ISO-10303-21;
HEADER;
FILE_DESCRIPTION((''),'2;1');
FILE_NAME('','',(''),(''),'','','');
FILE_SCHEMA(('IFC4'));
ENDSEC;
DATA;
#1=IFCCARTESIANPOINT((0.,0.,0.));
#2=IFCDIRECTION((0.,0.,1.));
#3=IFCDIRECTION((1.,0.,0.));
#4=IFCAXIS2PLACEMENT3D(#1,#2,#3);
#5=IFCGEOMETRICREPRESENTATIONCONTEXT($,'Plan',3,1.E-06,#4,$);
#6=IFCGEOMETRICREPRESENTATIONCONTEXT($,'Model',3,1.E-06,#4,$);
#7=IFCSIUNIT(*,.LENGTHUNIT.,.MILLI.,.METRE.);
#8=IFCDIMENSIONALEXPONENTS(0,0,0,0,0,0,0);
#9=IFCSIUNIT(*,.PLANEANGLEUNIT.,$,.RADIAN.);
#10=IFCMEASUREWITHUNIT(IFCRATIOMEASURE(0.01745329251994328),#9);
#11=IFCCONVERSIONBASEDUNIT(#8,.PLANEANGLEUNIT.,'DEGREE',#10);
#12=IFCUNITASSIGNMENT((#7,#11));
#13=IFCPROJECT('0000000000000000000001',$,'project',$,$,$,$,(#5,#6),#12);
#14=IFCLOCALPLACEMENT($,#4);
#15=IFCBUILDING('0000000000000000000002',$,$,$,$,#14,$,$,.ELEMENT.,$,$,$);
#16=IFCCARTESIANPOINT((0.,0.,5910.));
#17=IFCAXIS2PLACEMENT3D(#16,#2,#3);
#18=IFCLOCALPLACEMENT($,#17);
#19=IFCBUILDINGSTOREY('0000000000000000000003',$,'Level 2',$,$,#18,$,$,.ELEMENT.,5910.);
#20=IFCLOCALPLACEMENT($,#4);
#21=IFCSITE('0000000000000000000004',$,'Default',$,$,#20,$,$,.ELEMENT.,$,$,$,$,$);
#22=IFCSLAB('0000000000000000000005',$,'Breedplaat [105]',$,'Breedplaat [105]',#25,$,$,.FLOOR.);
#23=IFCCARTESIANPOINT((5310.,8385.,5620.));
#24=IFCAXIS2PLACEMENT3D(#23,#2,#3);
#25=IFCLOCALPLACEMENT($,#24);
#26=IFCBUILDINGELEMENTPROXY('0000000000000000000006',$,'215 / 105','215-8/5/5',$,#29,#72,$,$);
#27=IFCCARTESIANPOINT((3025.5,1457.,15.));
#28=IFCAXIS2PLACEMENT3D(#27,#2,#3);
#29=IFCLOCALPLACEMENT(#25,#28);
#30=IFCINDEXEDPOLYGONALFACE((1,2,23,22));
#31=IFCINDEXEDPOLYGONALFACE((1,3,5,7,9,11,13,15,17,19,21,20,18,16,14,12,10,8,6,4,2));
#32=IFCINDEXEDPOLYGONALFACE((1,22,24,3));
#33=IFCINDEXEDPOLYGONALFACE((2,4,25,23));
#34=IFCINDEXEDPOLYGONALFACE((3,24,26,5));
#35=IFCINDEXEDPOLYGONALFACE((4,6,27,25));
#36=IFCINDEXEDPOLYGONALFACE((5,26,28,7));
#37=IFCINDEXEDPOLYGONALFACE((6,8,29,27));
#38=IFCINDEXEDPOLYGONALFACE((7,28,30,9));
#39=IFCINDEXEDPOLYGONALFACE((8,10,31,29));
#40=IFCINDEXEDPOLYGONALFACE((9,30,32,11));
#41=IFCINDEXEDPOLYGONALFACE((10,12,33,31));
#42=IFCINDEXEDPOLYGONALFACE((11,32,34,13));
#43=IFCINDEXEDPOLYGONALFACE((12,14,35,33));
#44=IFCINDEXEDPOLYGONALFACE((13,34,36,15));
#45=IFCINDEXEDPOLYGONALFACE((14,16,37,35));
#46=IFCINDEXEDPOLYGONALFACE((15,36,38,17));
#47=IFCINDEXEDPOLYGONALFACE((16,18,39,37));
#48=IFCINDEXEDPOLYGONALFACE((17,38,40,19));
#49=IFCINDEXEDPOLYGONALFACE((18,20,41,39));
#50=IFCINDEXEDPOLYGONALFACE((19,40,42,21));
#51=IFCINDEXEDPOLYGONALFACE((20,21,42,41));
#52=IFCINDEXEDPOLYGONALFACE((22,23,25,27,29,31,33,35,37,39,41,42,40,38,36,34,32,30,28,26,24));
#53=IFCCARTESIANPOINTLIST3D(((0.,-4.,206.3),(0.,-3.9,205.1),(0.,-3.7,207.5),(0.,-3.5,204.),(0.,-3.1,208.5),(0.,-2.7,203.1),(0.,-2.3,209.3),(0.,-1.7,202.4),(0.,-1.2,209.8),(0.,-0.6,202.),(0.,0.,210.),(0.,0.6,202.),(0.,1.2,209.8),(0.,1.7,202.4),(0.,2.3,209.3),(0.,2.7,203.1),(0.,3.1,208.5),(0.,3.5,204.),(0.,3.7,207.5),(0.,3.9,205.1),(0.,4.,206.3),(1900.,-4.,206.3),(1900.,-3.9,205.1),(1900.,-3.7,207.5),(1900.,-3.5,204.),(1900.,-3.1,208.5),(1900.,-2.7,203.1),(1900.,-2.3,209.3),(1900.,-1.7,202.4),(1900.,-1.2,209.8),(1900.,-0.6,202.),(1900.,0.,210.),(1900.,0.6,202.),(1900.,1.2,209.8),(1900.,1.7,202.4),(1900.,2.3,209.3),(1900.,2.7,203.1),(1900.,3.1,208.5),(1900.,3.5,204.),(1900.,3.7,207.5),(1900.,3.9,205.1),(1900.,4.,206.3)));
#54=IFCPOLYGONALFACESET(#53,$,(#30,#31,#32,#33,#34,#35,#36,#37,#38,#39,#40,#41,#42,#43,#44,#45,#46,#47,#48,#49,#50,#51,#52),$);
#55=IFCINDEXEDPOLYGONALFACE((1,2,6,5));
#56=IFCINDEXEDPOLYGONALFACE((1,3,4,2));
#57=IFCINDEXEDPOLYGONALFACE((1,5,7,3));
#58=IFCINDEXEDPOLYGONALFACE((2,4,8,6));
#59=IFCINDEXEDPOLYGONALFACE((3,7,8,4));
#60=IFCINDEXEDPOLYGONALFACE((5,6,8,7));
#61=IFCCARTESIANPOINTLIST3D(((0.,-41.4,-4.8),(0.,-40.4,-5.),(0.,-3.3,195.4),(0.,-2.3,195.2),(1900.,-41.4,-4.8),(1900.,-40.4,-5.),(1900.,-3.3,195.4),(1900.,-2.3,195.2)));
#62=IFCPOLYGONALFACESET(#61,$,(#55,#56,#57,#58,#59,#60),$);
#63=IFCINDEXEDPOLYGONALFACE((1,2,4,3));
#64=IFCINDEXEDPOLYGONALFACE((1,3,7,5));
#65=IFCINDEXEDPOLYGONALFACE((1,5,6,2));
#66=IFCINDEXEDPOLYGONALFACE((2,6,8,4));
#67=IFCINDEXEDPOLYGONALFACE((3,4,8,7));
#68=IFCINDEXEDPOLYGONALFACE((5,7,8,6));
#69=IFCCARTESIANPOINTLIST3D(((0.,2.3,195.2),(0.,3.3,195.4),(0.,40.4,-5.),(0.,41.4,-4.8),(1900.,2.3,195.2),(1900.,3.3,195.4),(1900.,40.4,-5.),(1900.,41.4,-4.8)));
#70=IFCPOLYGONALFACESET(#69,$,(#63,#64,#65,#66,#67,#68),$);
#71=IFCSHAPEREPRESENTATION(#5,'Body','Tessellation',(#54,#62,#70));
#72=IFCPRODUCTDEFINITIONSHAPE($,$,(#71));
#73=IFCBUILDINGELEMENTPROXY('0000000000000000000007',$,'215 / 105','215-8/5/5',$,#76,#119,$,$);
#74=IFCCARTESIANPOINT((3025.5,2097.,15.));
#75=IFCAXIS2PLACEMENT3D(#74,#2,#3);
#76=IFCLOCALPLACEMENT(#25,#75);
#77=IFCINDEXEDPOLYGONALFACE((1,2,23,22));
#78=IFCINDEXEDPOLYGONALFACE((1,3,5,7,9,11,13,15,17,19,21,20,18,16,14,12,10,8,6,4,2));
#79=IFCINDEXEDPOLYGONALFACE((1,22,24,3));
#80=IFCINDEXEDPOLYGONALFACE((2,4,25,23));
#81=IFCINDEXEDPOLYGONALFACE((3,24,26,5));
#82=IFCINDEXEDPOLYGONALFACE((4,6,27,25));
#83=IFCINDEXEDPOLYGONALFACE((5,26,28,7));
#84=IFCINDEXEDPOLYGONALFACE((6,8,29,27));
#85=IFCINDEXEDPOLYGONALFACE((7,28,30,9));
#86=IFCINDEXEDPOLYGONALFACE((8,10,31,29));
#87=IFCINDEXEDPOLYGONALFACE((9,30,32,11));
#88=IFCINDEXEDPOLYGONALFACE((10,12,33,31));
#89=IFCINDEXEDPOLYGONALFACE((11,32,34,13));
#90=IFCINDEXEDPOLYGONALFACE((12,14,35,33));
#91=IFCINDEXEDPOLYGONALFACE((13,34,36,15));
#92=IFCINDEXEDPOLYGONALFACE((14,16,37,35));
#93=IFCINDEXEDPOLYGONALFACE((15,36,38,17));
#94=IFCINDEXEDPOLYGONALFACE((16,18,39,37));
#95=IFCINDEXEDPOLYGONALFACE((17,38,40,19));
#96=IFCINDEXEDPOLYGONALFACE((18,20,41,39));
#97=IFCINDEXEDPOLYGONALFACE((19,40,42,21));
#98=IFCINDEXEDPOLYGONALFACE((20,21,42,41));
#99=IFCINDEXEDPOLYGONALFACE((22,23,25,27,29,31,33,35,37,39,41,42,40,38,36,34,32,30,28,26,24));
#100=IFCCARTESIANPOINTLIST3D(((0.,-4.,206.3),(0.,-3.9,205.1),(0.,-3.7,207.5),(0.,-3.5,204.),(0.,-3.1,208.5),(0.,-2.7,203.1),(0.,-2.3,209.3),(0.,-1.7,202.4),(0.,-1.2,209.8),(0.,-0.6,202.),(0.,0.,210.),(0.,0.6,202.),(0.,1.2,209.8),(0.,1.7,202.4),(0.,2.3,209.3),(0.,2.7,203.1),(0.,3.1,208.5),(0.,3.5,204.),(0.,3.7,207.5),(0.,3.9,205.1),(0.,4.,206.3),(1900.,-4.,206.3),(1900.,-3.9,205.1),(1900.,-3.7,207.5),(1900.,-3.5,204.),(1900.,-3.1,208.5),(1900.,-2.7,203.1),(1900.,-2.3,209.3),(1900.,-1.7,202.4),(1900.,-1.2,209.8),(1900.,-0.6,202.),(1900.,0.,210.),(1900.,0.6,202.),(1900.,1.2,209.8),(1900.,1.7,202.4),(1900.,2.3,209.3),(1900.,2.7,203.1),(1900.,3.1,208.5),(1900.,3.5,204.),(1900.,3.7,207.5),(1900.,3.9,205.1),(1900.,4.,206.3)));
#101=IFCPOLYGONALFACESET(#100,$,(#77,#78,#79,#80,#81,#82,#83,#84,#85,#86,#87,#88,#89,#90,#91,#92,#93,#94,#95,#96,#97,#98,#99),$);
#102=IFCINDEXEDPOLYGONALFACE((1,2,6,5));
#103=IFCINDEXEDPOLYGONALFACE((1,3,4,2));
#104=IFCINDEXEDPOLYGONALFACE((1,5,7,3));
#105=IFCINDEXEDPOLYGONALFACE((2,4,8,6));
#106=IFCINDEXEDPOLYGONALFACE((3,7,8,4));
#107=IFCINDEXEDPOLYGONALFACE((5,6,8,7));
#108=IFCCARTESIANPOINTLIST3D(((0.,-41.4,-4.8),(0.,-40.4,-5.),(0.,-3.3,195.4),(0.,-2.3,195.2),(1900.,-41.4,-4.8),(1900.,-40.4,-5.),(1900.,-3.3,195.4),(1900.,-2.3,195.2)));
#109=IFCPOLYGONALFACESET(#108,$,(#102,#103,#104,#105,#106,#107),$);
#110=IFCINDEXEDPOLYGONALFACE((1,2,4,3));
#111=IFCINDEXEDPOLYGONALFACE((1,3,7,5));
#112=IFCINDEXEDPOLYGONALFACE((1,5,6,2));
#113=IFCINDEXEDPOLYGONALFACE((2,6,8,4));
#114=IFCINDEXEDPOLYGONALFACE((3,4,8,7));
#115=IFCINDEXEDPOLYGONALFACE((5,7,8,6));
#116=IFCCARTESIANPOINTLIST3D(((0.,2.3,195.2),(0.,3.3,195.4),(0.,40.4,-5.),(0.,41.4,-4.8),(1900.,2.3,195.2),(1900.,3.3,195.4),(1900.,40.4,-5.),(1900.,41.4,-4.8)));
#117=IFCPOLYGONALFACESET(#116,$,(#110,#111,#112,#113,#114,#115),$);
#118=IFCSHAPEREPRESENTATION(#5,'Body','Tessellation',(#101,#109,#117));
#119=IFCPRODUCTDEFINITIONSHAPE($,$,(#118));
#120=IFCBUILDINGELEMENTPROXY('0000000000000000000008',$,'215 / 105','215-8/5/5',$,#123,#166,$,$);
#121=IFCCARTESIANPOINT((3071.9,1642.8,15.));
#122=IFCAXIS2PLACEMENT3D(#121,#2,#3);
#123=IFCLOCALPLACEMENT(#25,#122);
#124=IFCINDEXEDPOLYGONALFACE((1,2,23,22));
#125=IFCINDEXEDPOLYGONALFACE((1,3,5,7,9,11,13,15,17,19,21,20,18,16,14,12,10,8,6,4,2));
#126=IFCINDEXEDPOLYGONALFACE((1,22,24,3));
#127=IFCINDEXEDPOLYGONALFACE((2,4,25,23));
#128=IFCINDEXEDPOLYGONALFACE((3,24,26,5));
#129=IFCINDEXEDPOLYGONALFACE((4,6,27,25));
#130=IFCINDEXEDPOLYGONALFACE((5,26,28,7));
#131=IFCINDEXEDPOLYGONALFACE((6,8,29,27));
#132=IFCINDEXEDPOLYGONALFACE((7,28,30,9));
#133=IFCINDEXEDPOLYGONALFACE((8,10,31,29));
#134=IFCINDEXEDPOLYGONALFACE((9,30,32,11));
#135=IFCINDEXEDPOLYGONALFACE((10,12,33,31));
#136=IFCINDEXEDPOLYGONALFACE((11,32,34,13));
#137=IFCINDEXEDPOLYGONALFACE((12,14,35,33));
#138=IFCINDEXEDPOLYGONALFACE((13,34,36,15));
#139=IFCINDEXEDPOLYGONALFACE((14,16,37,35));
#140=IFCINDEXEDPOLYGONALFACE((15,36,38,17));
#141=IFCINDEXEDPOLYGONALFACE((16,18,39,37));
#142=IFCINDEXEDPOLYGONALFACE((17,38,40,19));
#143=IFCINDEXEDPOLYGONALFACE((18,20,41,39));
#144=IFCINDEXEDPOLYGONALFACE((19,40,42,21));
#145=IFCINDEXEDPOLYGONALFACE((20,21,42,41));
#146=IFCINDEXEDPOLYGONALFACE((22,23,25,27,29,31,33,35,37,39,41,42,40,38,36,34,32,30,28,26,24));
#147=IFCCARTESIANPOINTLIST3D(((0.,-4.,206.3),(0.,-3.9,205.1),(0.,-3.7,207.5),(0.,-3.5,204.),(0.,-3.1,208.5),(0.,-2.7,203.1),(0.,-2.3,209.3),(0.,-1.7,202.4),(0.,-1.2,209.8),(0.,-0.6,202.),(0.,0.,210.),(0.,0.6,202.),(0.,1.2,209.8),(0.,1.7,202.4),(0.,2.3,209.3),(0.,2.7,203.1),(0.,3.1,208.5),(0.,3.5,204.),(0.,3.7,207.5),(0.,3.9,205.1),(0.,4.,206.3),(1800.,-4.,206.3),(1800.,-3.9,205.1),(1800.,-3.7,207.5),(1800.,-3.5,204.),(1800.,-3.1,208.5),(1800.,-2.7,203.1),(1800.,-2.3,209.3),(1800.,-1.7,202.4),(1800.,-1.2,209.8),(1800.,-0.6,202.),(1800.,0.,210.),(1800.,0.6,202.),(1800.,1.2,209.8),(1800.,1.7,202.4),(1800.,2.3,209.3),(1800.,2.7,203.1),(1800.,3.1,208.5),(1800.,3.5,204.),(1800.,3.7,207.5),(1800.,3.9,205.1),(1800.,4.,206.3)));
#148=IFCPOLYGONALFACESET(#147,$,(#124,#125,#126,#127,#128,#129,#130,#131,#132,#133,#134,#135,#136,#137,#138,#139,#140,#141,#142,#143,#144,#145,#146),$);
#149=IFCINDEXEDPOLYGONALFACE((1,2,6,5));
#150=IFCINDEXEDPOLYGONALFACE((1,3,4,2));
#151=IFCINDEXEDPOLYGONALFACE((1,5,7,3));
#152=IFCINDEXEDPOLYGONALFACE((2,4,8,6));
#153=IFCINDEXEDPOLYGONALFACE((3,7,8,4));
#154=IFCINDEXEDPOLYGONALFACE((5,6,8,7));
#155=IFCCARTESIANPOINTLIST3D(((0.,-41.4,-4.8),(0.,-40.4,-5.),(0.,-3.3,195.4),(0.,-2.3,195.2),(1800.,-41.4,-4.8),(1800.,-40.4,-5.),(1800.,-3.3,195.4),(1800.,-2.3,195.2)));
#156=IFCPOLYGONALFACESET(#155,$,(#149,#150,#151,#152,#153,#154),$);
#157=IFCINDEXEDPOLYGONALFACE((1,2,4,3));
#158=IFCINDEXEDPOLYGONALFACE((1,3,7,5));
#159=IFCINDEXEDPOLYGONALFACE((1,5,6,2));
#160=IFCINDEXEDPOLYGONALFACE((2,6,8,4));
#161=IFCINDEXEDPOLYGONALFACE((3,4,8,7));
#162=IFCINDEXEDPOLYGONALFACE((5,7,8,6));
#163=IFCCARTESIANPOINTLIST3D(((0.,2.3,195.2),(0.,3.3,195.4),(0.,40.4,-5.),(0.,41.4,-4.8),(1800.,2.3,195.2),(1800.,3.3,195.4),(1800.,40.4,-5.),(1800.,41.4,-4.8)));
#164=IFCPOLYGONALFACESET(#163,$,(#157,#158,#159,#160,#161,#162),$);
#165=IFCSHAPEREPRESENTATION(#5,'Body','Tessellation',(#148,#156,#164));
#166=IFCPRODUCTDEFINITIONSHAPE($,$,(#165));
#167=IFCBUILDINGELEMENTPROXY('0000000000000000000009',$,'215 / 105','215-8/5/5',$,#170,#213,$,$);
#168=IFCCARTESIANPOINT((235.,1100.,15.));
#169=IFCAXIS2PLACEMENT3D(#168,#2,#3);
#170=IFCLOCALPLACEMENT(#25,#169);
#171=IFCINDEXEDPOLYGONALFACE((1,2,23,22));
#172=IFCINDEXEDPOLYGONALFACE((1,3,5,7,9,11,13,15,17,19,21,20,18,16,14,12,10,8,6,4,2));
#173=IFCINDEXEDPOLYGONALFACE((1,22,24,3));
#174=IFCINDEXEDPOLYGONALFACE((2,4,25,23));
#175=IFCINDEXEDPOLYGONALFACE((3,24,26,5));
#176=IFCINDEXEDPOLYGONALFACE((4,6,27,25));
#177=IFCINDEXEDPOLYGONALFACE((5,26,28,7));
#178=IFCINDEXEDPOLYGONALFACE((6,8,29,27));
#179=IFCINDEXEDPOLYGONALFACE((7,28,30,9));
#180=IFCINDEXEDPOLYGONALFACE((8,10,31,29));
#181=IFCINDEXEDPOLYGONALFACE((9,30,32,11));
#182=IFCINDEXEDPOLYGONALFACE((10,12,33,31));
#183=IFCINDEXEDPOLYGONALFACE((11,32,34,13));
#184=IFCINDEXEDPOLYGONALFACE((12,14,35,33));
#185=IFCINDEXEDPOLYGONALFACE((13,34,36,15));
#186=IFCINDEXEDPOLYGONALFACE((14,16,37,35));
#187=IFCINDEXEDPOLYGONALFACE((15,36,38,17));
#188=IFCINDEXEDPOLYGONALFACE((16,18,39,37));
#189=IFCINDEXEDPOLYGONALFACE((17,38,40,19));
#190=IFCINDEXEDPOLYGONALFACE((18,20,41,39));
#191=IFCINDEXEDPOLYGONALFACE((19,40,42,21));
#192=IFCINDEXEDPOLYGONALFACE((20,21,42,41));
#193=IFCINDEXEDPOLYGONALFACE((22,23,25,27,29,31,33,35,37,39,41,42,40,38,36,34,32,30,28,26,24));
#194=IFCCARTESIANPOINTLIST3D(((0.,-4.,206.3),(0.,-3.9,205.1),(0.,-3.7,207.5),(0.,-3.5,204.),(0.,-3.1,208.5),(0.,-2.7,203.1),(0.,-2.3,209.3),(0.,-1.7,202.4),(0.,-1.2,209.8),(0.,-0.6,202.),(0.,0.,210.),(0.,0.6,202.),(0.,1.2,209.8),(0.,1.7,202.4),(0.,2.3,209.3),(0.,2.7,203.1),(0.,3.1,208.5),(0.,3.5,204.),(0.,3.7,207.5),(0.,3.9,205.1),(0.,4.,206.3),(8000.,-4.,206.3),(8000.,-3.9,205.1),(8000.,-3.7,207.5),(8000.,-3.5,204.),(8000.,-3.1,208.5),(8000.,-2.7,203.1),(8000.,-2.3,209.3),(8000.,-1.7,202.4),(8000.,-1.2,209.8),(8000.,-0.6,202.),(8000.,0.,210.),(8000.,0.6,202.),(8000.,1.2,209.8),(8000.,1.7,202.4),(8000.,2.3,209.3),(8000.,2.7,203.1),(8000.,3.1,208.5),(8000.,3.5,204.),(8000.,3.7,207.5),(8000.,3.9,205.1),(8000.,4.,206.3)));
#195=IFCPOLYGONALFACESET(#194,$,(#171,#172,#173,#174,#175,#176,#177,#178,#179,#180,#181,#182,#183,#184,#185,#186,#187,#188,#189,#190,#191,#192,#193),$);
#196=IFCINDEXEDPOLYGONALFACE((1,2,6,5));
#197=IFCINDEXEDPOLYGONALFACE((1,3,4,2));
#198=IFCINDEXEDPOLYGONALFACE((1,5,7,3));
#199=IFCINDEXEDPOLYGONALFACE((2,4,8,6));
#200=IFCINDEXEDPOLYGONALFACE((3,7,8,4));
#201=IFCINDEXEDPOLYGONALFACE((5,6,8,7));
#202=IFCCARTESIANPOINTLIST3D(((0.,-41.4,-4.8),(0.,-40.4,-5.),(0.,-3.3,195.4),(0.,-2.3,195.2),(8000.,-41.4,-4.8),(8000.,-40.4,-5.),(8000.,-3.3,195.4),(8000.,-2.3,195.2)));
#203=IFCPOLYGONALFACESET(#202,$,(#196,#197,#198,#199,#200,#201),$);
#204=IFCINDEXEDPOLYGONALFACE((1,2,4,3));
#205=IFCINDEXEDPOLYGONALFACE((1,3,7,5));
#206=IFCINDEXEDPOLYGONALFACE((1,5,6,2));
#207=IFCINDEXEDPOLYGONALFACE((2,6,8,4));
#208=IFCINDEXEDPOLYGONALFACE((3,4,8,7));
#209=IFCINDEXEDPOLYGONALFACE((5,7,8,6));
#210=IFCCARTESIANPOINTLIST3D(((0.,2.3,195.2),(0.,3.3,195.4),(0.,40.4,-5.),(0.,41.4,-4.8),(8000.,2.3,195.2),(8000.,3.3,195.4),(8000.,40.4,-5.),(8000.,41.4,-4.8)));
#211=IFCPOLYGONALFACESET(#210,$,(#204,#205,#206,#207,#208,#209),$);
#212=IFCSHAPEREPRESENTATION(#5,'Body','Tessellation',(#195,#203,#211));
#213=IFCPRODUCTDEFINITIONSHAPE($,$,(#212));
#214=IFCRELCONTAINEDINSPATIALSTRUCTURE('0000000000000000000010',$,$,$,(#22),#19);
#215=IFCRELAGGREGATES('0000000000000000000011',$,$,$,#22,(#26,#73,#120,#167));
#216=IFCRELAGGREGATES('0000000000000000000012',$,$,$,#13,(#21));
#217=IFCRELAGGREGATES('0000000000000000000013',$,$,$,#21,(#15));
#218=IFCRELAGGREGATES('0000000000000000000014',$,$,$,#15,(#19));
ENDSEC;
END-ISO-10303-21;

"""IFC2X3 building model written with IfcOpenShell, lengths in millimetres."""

from ifc_helpers import new_model, entity, si_unit, converted_unit, frame, origin_with_axes, origin_2d_with_axis, place, context, project, spatial, rectangle, circle, extrude, element, aggregate, save


model = new_model("IFC2X3")

# Units and contexts
plan_context = context("Plan", 3, precision=1e-06, world=origin_with_axes())
model_context = context("Model", 3, precision=1e-06, world=origin_with_axes())
ifc_project = project(units=[si_unit("LENGTHUNIT", "METRE", prefix="MILLI"), converted_unit("PLANEANGLEUNIT", "DEGREE", entity("IfcRatioMeasure", 0.01745329251994328), si_unit("PLANEANGLEUNIT", "RADIAN"), dimensions=[0, 0, 0, 0, 0, 0, 0])], contexts=[plan_context, model_context])

# Site, building, storey
site_placement = place(None, origin_with_axes())
site = spatial("IfcSite", under=ifc_project, at=site_placement, Name="Default", CompositionType="ELEMENT")
building_placement = place(None, origin_with_axes())
building = spatial("IfcBuilding", under=site, at=building_placement, CompositionType="ELEMENT")
storey_placement = place(None, frame((0.0, 0.0, 5910.0), z_axis=(0.0, 0.0, 1.0), x_axis=(1.0, 0.0, 0.0)))
storey = spatial("IfcBuildingStorey", under=building, at=storey_placement, Name="Level 2", CompositionType="ELEMENT", Elevation=5910.0)

# Slab, building element proxies
slab_1_placement = place(None, frame((5310.0, 8385.0, 5620.0), z_axis=(0.0, 0.0, 1.0), x_axis=(1.0, 0.0, 0.0)))
slab_1 = element("IfcSlab", 1, at=slab_1_placement, inside=storey, Name="Breedplaat [105]", ObjectType="Breedplaat [105]", PredefinedType="FLOOR")
proxy_1_placement = place(slab_1_placement, frame((3025.5, 1457.0, 15.0), z_axis=(0.0, 0.0, 1.0), x_axis=(1.0, 0.0, 0.0)))
proxy_1 = element("IfcBuildingElementProxy", 2, at=proxy_1_placement, Name="215 / 105", Description="215-8/5/5", context=plan_context, shape_type="SweptSolid", body=[
    extrude(circle(Radius=4.0, at=origin_2d_with_axis()), frame((0.0, 0.0, 206.0), z_axis=(1.0, 0.0, 0.0), x_axis=(0.0, 0.0, 1.0)), (0.0, 0.0, 1.0), 1900.0),
    extrude(rectangle(XDim=203.8, YDim=1.0, at=origin_2d_with_axis()), frame((0.0, -21.9, 95.2), z_axis=(1.0, 0.0, 0.0), x_axis=(0.0, 0.187112, 0.982339)), (0.0, 0.0, 1.0), 1900.0),
    extrude(rectangle(XDim=203.8, YDim=1.0, at=origin_2d_with_axis()), frame((0.0, 21.9, 95.2), z_axis=(1.0, 0.0, 0.0), x_axis=(0.0, -0.187112, 0.982339)), (0.0, 0.0, 1.0), 1900.0),
])
proxy_2_placement = place(slab_1_placement, frame((3025.5, 2097.0, 15.0), z_axis=(0.0, 0.0, 1.0), x_axis=(1.0, 0.0, 0.0)))
proxy_2 = element("IfcBuildingElementProxy", 3, at=proxy_2_placement, Name="215 / 105", Description="215-8/5/5", context=plan_context, shape_type="SweptSolid", body=[
    extrude(circle(Radius=4.0, at=origin_2d_with_axis()), frame((0.0, 0.0, 206.0), z_axis=(1.0, 0.0, 0.0), x_axis=(0.0, 0.0, 1.0)), (0.0, 0.0, 1.0), 1900.0),
    extrude(rectangle(XDim=203.8, YDim=1.0, at=origin_2d_with_axis()), frame((0.0, -21.9, 95.2), z_axis=(1.0, 0.0, 0.0), x_axis=(0.0, 0.187112, 0.982339)), (0.0, 0.0, 1.0), 1900.0),
    extrude(rectangle(XDim=203.8, YDim=1.0, at=origin_2d_with_axis()), frame((0.0, 21.9, 95.2), z_axis=(1.0, 0.0, 0.0), x_axis=(0.0, -0.187112, 0.982339)), (0.0, 0.0, 1.0), 1900.0),
])
proxy_3_placement = place(slab_1_placement, frame((3071.9, 1642.8, 15.0), z_axis=(0.0, 0.0, 1.0), x_axis=(1.0, 0.0, 0.0)))
proxy_3 = element("IfcBuildingElementProxy", 4, at=proxy_3_placement, Name="215 / 105", Description="215-8/5/5", context=plan_context, shape_type="SweptSolid", body=[
    extrude(circle(Radius=4.0, at=origin_2d_with_axis()), frame((0.0, 0.0, 206.0), z_axis=(1.0, 0.0, 0.0), x_axis=(0.0, 0.0, 1.0)), (0.0, 0.0, 1.0), 1800.0),
    extrude(rectangle(XDim=203.8, YDim=1.0, at=origin_2d_with_axis()), frame((0.0, -21.9, 95.2), z_axis=(1.0, 0.0, 0.0), x_axis=(0.0, 0.187112, 0.982339)), (0.0, 0.0, 1.0), 1800.0),
    extrude(rectangle(XDim=203.8, YDim=1.0, at=origin_2d_with_axis()), frame((0.0, 21.9, 95.2), z_axis=(1.0, 0.0, 0.0), x_axis=(0.0, -0.187112, 0.982339)), (0.0, 0.0, 1.0), 1800.0),
])
proxy_4_placement = place(slab_1_placement, frame((235.0, 1100.0, 15.0), z_axis=(0.0, 0.0, 1.0), x_axis=(1.0, 0.0, 0.0)))
proxy_4 = element("IfcBuildingElementProxy", 5, at=proxy_4_placement, Name="215 / 105", Description="215-8/5/5", context=plan_context, shape_type="SweptSolid", body=[
    extrude(circle(Radius=4.0, at=origin_2d_with_axis()), frame((0.0, 0.0, 206.0), z_axis=(1.0, 0.0, 0.0), x_axis=(0.0, 0.0, 1.0)), (0.0, 0.0, 1.0), 8000.0),
    extrude(rectangle(XDim=203.8, YDim=1.0, at=origin_2d_with_axis()), frame((0.0, -21.9, 95.2), z_axis=(1.0, 0.0, 0.0), x_axis=(0.0, 0.187112, 0.982339)), (0.0, 0.0, 1.0), 8000.0),
    extrude(rectangle(XDim=203.8, YDim=1.0, at=origin_2d_with_axis()), frame((0.0, 21.9, 95.2), z_axis=(1.0, 0.0, 0.0), x_axis=(0.0, -0.187112, 0.982339)), (0.0, 0.0, 1.0), 8000.0),
])
aggregate(slab_1, [proxy_1, proxy_2, proxy_3, proxy_4])

save(model, "model.ifc")
